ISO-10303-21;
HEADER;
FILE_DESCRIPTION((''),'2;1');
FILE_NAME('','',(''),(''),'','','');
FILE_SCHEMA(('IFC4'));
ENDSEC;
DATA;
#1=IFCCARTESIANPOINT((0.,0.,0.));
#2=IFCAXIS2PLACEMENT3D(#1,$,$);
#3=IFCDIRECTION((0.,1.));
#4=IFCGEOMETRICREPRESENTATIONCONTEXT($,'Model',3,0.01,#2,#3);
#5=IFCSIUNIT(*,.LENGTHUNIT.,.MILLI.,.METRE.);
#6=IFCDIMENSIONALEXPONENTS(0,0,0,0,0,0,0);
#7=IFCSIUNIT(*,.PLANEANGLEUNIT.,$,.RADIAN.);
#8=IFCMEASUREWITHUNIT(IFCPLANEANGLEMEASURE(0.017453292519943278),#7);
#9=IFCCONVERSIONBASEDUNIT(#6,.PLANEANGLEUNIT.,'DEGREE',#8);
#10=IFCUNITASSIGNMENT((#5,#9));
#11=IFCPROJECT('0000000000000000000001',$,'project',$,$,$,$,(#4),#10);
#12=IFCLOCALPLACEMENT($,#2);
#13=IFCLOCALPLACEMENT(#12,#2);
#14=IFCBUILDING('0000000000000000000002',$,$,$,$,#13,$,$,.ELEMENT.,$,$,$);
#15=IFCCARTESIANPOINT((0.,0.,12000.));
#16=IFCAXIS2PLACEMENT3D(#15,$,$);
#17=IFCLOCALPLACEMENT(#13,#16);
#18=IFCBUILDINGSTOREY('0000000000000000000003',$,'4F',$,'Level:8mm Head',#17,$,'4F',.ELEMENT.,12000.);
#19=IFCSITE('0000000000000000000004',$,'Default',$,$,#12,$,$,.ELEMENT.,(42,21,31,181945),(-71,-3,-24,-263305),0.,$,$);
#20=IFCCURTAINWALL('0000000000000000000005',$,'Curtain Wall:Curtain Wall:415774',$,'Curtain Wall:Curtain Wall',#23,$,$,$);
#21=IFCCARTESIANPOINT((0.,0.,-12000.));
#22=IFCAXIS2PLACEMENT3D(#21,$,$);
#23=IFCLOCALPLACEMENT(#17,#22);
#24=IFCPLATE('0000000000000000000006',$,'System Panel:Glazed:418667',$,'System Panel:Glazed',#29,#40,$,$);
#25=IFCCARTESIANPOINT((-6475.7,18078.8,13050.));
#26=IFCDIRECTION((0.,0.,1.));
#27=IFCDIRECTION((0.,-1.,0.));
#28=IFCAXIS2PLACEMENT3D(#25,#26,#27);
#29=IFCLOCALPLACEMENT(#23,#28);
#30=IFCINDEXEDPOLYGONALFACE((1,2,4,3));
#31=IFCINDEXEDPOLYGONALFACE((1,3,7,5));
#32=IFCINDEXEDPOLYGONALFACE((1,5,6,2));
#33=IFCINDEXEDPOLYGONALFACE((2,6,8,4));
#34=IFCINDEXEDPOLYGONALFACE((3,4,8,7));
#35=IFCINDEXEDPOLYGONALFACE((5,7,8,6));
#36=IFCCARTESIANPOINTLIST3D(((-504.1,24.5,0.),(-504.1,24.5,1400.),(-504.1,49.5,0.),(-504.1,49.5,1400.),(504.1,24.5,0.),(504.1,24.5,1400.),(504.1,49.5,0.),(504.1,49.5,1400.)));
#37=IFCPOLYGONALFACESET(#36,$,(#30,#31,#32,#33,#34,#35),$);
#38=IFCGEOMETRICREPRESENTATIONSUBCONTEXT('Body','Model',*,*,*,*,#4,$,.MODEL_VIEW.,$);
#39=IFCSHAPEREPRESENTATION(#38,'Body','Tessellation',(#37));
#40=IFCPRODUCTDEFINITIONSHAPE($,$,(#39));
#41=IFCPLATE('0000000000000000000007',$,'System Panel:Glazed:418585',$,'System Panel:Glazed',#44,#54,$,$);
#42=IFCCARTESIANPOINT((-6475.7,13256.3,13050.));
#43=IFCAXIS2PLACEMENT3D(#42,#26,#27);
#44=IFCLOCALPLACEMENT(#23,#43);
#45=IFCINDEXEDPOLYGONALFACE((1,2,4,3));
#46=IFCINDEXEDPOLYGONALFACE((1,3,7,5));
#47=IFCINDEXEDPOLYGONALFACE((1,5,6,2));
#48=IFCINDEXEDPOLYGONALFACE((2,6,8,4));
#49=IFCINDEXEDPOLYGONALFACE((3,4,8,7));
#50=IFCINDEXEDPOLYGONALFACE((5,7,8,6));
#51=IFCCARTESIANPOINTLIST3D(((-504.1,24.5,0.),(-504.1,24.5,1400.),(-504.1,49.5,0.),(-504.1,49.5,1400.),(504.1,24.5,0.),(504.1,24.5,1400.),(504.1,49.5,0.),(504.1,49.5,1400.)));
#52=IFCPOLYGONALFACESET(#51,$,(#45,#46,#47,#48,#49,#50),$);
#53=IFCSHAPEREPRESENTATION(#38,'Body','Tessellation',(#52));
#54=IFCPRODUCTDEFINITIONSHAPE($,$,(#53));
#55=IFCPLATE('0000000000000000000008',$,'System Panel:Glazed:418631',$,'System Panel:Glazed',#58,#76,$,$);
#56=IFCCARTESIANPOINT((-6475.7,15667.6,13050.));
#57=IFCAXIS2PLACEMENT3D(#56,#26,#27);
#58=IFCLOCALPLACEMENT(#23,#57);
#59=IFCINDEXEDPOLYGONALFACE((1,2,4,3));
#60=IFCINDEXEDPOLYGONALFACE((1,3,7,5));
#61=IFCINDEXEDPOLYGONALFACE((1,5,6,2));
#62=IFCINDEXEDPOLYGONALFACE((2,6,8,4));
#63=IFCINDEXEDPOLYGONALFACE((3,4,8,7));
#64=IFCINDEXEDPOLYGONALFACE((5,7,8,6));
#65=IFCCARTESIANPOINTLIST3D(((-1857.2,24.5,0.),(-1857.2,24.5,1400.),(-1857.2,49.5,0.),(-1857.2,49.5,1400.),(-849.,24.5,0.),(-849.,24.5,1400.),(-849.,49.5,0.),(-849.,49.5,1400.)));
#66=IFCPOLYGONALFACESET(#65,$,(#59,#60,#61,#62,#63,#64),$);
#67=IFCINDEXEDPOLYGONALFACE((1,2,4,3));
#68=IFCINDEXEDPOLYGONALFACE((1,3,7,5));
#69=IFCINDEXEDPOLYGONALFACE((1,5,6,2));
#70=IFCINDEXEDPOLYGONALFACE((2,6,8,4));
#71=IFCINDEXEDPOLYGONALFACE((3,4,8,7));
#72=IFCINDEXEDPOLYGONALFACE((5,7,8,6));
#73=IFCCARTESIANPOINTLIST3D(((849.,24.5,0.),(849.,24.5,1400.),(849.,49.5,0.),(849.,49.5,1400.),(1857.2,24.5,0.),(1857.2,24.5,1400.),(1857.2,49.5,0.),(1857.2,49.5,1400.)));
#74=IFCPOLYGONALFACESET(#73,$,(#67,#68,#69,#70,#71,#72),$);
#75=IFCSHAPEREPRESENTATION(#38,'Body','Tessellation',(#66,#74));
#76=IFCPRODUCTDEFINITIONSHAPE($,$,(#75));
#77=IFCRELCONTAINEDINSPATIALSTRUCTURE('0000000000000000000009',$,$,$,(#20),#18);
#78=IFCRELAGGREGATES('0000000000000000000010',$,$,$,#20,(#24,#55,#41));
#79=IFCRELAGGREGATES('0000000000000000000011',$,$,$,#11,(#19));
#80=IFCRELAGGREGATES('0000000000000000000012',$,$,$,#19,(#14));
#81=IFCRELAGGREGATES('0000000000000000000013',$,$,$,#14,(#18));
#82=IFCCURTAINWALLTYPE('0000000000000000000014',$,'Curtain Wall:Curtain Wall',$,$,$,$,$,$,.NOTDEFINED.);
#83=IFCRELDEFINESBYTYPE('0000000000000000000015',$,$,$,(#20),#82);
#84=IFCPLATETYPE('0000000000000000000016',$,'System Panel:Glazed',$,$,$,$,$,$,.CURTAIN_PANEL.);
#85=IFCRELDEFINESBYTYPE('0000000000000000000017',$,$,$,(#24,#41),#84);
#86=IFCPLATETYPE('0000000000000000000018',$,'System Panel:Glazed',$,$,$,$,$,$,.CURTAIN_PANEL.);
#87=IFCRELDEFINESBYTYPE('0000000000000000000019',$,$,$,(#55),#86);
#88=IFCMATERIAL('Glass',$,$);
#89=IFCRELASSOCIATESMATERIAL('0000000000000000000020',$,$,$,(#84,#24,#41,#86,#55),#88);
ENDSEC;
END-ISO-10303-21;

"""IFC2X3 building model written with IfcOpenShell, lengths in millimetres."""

from ifc_helpers import new_model, entity, si_unit, converted_unit, direction, frame, origin, origin_2d_with_axis, place, context, subcontext, project, spatial, rectangle, extrude, source, transform, mapped, material, type_object, type_shapes, element, aggregate, save


model = new_model("IFC2X3")

# Units and contexts
model_context = context("Model", 3, precision=0.01, world=origin(), true_north=direction((0.0, 1.0)))
body_context = subcontext(model_context, "Body", "Model", "MODEL_VIEW")
ifc_project = project(units=[si_unit("LENGTHUNIT", "METRE", prefix="MILLI"), converted_unit("PLANEANGLEUNIT", "DEGREE", entity("IfcPlaneAngleMeasure", 0.017453292519943278), si_unit("PLANEANGLEUNIT", "RADIAN"), dimensions=[0, 0, 0, 0, 0, 0, 0])], contexts=[model_context])

# Site, building, storey
site_placement = place(None, origin())
site = spatial("IfcSite", under=ifc_project, at=site_placement, Name="Default", CompositionType="ELEMENT", RefLatitude=(42, 21, 31, 181945), RefLongitude=(-71, -3, -24, -263305), RefElevation=0.0)
building_placement = place(site_placement, origin())
building = spatial("IfcBuilding", under=site, at=building_placement, CompositionType="ELEMENT")
storey_placement = place(building_placement, frame((0.0, 0.0, 12000.0)))
storey = spatial("IfcBuildingStorey", under=building, at=storey_placement, Name="4F", ObjectType="Level:8mm Head", LongName="4F", CompositionType="ELEMENT", Elevation=12000.0)

# Curtain wall, plates
curtain_wall_type = type_object("IfcCurtainWallType", Name="Curtain Wall:Curtain Wall", PredefinedType="NOTDEFINED")
curtain_wall_placement = place(storey_placement, frame((0.0, 0.0, -12000.0)))
curtain_wall = element("IfcCurtainWall", 1, at=curtain_wall_placement, inside=storey, type_object=curtain_wall_type, Name="Curtain Wall:Curtain Wall:415774", ObjectType="Curtain Wall:Curtain Wall")
ifc_material_1 = material(Name="Glass")
plate_type_1 = type_object("IfcPlateType", Name="System Panel:Glazed", PredefinedType="CURTAIN_PANEL", material=ifc_material_1)
shared_shape_1 = source(origin(), body_context, "Body", "SweptSolid", [
    extrude(rectangle(XDim=25.0, YDim=1008.2, at=origin_2d_with_axis()), frame((0.0, 37.0, 0.0), z_axis=(0.0, 0.0, 1.0), x_axis=(0.0, 1.0, 0.0)), (0.0, 0.0, 1.0), 1400.0),
])
type_shapes(plate_type_1, [shared_shape_1])
plate_1_placement = place(curtain_wall_placement, frame((-6475.7, 18078.8, 13050.0), z_axis=(0.0, 0.0, 1.0), x_axis=(0.0, -1.0, 0.0)))
plate_1 = element("IfcPlate", 2, at=plate_1_placement, type_object=plate_type_1, material=ifc_material_1, Name="System Panel:Glazed:418667", ObjectType="System Panel:Glazed", context=body_context, shape_type="MappedRepresentation", body=[
    mapped(shared_shape_1, transform((0.0, 0.0, 0.0), scale=1.0)),
])
plate_2_placement = place(curtain_wall_placement, frame((-6475.7, 13256.3, 13050.0), z_axis=(0.0, 0.0, 1.0), x_axis=(0.0, -1.0, 0.0)))
plate_2 = element("IfcPlate", 3, at=plate_2_placement, type_object=plate_type_1, material=ifc_material_1, Name="System Panel:Glazed:418585", ObjectType="System Panel:Glazed", context=body_context, shape_type="MappedRepresentation", body=[
    mapped(shared_shape_1, transform((0.0, 0.0, 0.0), scale=1.0)),
])
plate_type_2 = type_object("IfcPlateType", Name="System Panel:Glazed", PredefinedType="CURTAIN_PANEL", material=ifc_material_1)
shared_shape_2 = source(origin(), body_context, "Body", "SweptSolid", [
    extrude(rectangle(XDim=25.0, YDim=1008.2, at=origin_2d_with_axis()), frame((-1353.1, 37.0, 0.0), z_axis=(0.0, 0.0, 1.0), x_axis=(0.0, 1.0, 0.0)), (0.0, 0.0, 1.0), 1400.0),
    extrude(rectangle(XDim=25.0, YDim=1008.2, at=origin_2d_with_axis()), frame((1353.1, 37.0, 0.0), z_axis=(0.0, 0.0, 1.0), x_axis=(0.0, 1.0, 0.0)), (0.0, 0.0, 1.0), 1400.0),
])
type_shapes(plate_type_2, [shared_shape_2])
plate_3_placement = place(curtain_wall_placement, frame((-6475.7, 15667.6, 13050.0), z_axis=(0.0, 0.0, 1.0), x_axis=(0.0, -1.0, 0.0)))
plate_3 = element("IfcPlate", 4, at=plate_3_placement, type_object=plate_type_2, material=ifc_material_1, Name="System Panel:Glazed:418631", ObjectType="System Panel:Glazed", context=body_context, shape_type="MappedRepresentation", body=[
    mapped(shared_shape_2, transform((0.0, 0.0, 0.0), scale=1.0)),
])
aggregate(curtain_wall, [plate_1, plate_3, plate_2])

save(model, "model.ifc")
